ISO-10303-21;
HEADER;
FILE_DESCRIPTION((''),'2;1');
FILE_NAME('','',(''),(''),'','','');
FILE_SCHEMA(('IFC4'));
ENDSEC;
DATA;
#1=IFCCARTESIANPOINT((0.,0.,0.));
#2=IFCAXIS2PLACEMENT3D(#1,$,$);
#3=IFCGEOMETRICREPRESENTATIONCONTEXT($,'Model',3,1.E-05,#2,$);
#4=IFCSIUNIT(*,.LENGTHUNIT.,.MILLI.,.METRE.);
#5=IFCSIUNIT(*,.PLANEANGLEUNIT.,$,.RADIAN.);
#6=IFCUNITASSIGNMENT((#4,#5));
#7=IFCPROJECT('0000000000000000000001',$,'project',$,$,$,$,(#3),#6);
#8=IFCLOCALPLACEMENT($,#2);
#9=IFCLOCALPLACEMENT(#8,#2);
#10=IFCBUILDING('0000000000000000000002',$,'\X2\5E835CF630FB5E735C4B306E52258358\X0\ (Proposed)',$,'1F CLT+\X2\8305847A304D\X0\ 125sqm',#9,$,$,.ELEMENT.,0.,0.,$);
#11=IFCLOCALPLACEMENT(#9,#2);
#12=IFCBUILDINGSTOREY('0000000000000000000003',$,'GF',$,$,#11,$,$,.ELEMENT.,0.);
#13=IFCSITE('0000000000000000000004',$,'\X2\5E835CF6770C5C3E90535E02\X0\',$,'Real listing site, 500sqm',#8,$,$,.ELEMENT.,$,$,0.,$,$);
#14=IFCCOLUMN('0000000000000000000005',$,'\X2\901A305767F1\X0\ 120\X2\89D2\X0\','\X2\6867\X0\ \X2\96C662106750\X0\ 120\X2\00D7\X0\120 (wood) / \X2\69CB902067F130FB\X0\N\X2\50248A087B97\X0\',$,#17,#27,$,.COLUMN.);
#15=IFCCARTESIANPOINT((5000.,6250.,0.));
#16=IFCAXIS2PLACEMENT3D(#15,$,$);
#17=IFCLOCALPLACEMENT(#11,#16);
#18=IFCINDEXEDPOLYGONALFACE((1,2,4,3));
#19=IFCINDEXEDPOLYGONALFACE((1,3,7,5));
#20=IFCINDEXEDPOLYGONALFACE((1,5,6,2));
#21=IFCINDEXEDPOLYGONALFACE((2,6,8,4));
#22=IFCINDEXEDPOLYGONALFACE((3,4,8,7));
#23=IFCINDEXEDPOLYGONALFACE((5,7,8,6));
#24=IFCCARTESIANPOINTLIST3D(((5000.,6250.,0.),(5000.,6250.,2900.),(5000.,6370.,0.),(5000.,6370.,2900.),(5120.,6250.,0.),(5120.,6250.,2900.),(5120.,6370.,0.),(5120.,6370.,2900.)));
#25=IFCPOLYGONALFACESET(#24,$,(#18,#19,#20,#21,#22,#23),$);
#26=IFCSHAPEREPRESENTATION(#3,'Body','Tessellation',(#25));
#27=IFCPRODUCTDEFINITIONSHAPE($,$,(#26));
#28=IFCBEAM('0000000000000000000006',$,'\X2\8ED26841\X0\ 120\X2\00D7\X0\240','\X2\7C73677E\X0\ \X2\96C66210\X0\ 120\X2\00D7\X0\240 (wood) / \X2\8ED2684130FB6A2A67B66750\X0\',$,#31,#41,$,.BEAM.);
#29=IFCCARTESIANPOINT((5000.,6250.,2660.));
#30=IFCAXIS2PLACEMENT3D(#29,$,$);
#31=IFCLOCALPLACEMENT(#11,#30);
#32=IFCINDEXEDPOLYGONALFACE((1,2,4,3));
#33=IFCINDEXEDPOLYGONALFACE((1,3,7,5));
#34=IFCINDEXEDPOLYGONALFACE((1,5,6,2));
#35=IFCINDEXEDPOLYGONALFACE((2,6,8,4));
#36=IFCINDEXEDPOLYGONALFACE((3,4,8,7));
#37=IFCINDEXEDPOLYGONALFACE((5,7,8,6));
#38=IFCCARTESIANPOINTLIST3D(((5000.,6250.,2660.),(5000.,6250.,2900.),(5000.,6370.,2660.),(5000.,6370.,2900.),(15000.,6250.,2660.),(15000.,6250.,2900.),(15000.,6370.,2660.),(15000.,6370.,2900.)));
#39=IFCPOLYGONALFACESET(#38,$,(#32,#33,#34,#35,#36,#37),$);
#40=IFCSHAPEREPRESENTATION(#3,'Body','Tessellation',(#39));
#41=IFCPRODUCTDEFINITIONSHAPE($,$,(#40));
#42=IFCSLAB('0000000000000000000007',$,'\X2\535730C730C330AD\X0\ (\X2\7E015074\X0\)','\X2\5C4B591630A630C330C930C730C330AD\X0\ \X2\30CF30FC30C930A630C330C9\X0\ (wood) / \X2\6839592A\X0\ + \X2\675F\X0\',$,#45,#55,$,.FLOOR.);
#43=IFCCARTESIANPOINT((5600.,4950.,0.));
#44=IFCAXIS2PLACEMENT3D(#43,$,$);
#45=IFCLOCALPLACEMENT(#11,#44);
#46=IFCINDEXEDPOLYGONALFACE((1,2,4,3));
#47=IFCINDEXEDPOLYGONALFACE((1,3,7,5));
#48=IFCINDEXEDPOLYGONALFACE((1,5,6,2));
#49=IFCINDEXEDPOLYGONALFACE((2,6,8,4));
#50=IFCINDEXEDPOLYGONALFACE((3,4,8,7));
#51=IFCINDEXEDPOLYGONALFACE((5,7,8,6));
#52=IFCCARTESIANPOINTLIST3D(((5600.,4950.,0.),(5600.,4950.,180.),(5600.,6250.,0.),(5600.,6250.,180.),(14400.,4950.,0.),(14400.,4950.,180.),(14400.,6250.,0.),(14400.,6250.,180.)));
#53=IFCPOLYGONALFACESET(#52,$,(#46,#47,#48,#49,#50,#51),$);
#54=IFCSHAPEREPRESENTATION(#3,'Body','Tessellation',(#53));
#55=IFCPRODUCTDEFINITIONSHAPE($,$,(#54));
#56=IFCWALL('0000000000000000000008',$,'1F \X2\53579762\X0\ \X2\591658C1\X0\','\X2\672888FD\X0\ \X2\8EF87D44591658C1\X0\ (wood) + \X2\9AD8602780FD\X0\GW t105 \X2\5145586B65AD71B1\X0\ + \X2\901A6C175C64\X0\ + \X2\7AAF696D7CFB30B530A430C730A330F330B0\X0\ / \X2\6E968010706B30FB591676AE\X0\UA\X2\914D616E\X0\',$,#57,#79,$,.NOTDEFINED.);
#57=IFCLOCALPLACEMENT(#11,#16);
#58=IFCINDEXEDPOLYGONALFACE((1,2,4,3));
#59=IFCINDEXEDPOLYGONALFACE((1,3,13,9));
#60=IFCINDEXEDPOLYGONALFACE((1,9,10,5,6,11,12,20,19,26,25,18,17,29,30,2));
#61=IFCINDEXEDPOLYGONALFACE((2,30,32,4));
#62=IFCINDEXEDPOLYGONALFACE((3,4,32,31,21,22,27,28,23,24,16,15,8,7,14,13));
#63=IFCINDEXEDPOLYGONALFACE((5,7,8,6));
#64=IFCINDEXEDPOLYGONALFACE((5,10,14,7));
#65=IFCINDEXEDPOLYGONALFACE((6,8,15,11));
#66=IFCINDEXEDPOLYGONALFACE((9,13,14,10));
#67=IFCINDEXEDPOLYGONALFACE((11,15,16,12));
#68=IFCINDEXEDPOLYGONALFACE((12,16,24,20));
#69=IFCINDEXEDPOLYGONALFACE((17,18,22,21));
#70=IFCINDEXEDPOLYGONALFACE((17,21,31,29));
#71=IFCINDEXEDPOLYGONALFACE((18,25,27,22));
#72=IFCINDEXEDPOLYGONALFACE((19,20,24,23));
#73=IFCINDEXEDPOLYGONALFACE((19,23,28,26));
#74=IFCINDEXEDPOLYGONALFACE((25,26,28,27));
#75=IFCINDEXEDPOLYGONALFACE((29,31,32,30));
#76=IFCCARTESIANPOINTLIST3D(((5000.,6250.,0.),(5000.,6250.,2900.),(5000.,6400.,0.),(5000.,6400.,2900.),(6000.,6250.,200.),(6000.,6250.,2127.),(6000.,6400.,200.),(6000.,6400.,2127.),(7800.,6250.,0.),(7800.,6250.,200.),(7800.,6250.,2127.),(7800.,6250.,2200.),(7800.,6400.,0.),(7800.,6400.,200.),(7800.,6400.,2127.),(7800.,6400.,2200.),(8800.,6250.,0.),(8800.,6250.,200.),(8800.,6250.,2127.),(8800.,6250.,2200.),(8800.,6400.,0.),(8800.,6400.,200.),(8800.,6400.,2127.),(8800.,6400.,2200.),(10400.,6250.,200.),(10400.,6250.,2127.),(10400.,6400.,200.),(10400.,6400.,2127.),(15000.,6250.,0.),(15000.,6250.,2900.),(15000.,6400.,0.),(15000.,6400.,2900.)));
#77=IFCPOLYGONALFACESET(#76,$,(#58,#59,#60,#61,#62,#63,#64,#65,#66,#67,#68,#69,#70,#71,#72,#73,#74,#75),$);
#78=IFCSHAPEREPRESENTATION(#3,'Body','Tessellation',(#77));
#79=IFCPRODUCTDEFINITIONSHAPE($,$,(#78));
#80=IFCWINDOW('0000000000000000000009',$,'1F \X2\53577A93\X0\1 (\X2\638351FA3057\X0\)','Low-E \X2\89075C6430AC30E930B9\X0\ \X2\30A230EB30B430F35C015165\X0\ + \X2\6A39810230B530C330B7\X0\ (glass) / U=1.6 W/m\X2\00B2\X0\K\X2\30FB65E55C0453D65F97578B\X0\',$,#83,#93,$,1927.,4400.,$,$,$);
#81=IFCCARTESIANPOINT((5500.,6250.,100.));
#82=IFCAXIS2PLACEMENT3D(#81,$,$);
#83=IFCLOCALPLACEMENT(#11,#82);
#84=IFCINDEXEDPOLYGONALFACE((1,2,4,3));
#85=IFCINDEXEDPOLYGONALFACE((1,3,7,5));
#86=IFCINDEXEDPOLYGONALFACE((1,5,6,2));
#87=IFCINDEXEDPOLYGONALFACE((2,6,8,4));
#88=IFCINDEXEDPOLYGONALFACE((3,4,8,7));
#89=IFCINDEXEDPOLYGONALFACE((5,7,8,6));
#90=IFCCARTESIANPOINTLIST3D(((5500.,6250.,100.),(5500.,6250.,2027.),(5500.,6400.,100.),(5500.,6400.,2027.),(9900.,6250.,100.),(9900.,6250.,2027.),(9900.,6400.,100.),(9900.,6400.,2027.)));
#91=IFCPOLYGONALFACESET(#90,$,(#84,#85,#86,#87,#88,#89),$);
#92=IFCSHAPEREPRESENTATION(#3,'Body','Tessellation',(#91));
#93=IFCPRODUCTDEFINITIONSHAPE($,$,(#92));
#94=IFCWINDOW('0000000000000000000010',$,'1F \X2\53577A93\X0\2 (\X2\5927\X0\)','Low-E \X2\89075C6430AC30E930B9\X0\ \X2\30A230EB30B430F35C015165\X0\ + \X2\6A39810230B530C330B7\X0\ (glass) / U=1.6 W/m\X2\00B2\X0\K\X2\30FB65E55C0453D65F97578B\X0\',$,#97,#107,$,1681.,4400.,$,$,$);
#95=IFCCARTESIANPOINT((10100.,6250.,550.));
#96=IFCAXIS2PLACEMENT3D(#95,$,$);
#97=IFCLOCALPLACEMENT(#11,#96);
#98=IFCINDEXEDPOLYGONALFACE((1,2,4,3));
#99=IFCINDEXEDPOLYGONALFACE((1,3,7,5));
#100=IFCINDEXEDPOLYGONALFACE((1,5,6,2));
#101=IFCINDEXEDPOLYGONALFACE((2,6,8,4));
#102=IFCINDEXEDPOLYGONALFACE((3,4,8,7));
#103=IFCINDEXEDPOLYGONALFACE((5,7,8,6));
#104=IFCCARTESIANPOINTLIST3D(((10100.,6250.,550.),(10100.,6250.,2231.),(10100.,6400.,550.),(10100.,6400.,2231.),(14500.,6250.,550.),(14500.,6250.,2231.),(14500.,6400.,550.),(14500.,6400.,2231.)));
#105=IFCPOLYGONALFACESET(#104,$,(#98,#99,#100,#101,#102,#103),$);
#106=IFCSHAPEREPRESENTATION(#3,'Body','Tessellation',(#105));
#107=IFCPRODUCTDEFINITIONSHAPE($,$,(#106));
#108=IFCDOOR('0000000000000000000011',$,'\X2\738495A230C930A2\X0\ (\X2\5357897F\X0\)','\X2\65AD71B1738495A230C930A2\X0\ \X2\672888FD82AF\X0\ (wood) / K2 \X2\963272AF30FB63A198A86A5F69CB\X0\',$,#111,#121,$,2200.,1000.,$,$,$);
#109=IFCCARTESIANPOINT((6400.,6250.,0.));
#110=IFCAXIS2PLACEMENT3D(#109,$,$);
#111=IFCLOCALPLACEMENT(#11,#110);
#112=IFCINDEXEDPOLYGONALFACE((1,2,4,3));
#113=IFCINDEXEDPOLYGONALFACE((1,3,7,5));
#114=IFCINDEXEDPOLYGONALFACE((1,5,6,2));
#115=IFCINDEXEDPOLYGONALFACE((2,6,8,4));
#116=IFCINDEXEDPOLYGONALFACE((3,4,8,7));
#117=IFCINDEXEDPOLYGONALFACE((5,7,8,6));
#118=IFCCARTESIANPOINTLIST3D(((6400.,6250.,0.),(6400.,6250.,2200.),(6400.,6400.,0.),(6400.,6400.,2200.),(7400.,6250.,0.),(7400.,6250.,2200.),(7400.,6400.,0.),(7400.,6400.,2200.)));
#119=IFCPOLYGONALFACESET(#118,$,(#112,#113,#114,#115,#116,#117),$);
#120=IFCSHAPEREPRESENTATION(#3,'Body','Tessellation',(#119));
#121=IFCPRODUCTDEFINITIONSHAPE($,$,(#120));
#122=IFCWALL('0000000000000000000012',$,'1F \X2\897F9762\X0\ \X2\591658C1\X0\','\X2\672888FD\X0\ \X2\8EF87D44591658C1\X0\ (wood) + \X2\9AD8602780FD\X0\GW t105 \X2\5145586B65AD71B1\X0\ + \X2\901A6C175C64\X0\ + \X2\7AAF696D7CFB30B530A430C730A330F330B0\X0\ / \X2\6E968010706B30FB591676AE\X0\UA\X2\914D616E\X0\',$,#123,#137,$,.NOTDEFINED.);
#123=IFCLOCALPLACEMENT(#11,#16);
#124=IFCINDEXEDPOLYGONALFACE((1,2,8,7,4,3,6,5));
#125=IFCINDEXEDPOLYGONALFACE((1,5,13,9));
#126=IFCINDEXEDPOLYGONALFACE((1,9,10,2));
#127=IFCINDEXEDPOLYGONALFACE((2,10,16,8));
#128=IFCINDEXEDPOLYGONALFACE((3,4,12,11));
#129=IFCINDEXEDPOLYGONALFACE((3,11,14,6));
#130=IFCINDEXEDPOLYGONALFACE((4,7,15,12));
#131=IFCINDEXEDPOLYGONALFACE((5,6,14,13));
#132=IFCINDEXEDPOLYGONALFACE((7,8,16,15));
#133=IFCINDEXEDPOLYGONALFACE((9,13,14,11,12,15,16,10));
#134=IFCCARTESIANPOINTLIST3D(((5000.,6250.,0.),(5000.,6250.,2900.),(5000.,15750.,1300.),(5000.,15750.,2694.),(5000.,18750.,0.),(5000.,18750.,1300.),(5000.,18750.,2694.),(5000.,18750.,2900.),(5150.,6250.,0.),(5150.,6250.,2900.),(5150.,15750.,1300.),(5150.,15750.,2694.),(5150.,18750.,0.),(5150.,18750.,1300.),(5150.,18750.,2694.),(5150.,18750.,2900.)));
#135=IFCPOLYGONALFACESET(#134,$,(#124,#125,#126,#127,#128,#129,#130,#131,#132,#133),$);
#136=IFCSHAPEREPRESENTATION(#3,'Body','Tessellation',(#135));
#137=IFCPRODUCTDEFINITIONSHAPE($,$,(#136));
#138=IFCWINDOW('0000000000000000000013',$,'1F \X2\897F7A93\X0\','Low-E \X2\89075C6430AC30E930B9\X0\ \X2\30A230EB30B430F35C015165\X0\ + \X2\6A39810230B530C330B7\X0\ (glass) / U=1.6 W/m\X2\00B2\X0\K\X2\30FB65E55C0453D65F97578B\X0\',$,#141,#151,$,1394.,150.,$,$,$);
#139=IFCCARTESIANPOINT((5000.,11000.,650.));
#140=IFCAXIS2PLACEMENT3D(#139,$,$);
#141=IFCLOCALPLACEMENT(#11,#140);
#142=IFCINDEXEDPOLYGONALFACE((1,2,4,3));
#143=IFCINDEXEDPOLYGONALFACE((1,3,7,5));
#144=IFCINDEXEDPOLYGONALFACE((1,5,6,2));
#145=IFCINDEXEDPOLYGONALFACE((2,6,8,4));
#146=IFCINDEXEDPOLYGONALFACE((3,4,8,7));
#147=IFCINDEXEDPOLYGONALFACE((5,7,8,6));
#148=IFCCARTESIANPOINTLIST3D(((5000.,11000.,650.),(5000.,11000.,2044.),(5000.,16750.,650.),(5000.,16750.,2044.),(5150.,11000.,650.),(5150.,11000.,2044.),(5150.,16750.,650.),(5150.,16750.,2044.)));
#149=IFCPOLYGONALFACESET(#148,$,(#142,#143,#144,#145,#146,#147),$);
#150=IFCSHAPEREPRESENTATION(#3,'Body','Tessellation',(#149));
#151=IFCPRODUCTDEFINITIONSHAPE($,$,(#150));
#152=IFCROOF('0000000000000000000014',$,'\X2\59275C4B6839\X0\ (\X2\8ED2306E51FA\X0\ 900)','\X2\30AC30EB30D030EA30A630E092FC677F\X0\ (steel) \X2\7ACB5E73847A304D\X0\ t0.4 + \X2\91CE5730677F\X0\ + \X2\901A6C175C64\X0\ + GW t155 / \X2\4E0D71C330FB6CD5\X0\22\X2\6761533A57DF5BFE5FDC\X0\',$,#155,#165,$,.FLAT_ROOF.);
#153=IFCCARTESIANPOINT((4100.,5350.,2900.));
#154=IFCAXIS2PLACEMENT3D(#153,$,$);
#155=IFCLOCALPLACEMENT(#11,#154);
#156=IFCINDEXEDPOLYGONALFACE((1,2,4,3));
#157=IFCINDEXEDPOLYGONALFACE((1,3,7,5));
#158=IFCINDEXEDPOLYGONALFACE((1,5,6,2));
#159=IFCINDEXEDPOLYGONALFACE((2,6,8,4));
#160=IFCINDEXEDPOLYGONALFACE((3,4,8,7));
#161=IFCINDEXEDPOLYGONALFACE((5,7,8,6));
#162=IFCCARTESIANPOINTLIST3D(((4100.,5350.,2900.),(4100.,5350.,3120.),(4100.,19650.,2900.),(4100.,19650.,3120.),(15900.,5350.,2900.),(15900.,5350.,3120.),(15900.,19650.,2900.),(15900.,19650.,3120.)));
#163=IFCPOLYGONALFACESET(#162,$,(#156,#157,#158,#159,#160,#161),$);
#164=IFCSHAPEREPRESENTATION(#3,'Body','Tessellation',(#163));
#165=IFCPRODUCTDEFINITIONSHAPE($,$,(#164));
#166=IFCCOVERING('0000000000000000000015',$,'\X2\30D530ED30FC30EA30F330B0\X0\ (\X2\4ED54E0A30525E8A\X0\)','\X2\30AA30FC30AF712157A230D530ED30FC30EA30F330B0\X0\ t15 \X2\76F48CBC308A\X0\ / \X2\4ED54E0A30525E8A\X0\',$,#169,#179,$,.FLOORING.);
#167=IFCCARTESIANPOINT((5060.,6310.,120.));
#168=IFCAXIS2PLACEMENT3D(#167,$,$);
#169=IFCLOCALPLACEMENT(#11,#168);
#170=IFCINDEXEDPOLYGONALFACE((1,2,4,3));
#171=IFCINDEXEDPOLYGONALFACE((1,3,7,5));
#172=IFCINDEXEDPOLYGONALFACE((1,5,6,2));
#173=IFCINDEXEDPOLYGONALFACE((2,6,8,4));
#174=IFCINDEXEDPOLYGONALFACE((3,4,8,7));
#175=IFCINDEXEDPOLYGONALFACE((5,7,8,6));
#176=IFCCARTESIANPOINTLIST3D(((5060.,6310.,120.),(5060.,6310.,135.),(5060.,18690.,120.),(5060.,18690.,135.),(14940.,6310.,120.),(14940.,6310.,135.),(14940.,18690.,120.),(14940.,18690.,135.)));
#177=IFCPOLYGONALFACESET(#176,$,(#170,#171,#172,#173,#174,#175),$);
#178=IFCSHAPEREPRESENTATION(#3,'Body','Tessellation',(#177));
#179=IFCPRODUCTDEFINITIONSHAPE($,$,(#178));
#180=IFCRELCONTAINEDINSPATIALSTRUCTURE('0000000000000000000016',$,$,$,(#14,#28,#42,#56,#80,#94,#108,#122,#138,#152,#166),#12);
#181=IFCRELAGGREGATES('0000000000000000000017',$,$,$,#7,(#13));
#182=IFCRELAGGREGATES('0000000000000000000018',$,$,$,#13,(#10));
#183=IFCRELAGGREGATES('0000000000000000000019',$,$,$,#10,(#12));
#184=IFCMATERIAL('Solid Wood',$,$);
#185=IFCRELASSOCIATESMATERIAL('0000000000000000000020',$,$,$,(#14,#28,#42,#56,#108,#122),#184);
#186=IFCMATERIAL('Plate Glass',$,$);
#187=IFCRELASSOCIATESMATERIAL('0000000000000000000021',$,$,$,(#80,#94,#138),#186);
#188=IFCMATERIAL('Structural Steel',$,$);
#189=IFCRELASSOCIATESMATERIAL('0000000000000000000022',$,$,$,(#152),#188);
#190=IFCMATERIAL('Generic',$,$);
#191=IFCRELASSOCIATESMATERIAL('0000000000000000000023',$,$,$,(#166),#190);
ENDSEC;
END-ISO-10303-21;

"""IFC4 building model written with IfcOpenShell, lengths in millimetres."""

from ifc_helpers import new_model, si_unit, frame, frame_2d, origin, place, context, project, spatial, rectangle, extrude, material, element, fill, save


model = new_model("IFC4")

# Units and contexts
model_context = context("Model", 3, precision=1e-05, world=origin())
ifc_project = project(units=[si_unit("LENGTHUNIT", "METRE", prefix="MILLI"), si_unit("PLANEANGLEUNIT", "RADIAN")], contexts=[model_context])

# Site, building, storey
site_placement = place(None, origin())
site = spatial("IfcSite", under=ifc_project, at=site_placement, Name="広島県尾道市", ObjectType="Real listing site, 500sqm", CompositionType="ELEMENT", RefElevation=0.0)
building_placement = place(site_placement, origin())
building = spatial("IfcBuilding", under=site, at=building_placement, Name="広島・平屋の別荘 (Proposed)", ObjectType="1F CLT+茅葺き 125sqm", CompositionType="ELEMENT", ElevationOfRefHeight=0.0, ElevationOfTerrain=0.0)
storey_placement = place(building_placement, origin())
storey = spatial("IfcBuildingStorey", under=building, at=storey_placement, Name="GF", CompositionType="ELEMENT", Elevation=0.0)

# Column
ifc_material_1 = material(Name="Solid Wood")
column_1_placement = place(storey_placement, frame((5000.0, 6250.0, 0.0)))
element("IfcColumn", 1, at=column_1_placement, inside=storey, material=ifc_material_1, Name="通し柱 120角", Description="桧 集成材 120×120 (wood) / 構造柱・N値計算", PredefinedType="COLUMN", context=model_context, shape_type="SweptSolid", body=[
    extrude(rectangle(XDim=120.0, YDim=120.0, at=frame_2d((60.0, 60.0))), frame((5000.0, 6250.0, 0.0)), (0.0, 0.0, 1.0), 2900.0),
])

# Beam
beam_1_placement = place(storey_placement, frame((5000.0, 6250.0, 2660.0)))
element("IfcBeam", 2, at=beam_1_placement, inside=storey, material=ifc_material_1, Name="軒桁 120×240", Description="米松 集成 120×240 (wood) / 軒桁・横架材", PredefinedType="BEAM", context=model_context, shape_type="SweptSolid", body=[
    extrude(rectangle(XDim=10000.0, YDim=120.0, at=frame_2d((5000.0, 60.0))), frame((5000.0, 6250.0, 2660.0)), (0.0, 0.0, 1.0), 240.0),
])

# Slab
slab_1_placement = place(storey_placement, frame((5600.0, 4950.0, 0.0)))
element("IfcSlab", 3, at=slab_1_placement, inside=storey, material=ifc_material_1, Name="南デッキ (縁側)", Description="屋外ウッドデッキ ハードウッド (wood) / 根太 + 束", PredefinedType="FLOOR", context=model_context, shape_type="SweptSolid", body=[
    extrude(rectangle(XDim=8800.0, YDim=1300.0, at=frame_2d((4400.0, 650.0))), frame((5600.0, 4950.0, 0.0)), (0.0, 0.0, 1.0), 180.0),
])

# Wall, openings, windows, door
wall_1_placement = place(storey_placement, frame((5000.0, 6250.0, 0.0)))
wall_1 = element("IfcWall", 4, at=wall_1_placement, inside=storey, material=ifc_material_1, Name="1F 南面 外壁", Description="木製 軸組外壁 (wood) + 高性能GW t105 充填断熱 + 通気層 + 窯業系サイディング / 準耐火・外皮UA配慮", PredefinedType="NOTDEFINED", context=model_context, shape_type="SweptSolid", body=[
    extrude(rectangle(XDim=10000.0, YDim=150.0, at=frame_2d((5000.0, 75.0))), frame((5000.0, 6250.0, 0.0)), (0.0, 0.0, 1.0), 2900.0),
])
opening_1_placement = place(storey_placement, frame((5500.0, 6250.0, 100.0)))
opening_1 = element("IfcOpeningElement", 5, at=opening_1_placement, cuts=wall_1, PredefinedType="NOTDEFINED", context=model_context, shape_type="SweptSolid", body=[
    extrude(rectangle(XDim=4400.0, YDim=150.0, at=frame_2d((2200.0, 75.0))), frame((5500.0, 6250.0, 100.0)), (0.0, 0.0, 1.0), 1927.0),
])
opening_2_placement = place(storey_placement, frame((10100.0, 6250.0, 550.0)))
opening_2 = element("IfcOpeningElement", 6, at=opening_2_placement, cuts=wall_1, PredefinedType="NOTDEFINED", context=model_context, shape_type="SweptSolid", body=[
    extrude(rectangle(XDim=4400.0, YDim=150.0, at=frame_2d((2200.0, 75.0))), frame((10100.0, 6250.0, 550.0)), (0.0, 0.0, 1.0), 1681.0),
])
opening_3_placement = place(storey_placement, frame((6400.0, 6250.0, 0.0)))
opening_3 = element("IfcOpeningElement", 7, at=opening_3_placement, cuts=wall_1, PredefinedType="NOTDEFINED", context=model_context, shape_type="SweptSolid", body=[
    extrude(rectangle(XDim=1000.0, YDim=150.0, at=frame_2d((500.0, 75.0))), frame((6400.0, 6250.0, 0.0)), (0.0, 0.0, 1.0), 2200.0),
])
ifc_material_2 = material(Name="Plate Glass")
window_1_placement = place(storey_placement, frame((5500.0, 6250.0, 100.0)))
window_1 = element("IfcWindow", 8, at=window_1_placement, inside=storey, material=ifc_material_2, Name="1F 南窓1 (掃出し)", Description="Low-E 複層ガラス アルゴン封入 + 樹脂サッシ (glass) / U=1.6 W/m²K・日射取得型", OverallHeight=1927.0, OverallWidth=4400.0, context=model_context, shape_type="SweptSolid", body=[
    extrude(rectangle(XDim=4400.0, YDim=150.0, at=frame_2d((2200.0, 75.0))), frame((5500.0, 6250.0, 100.0)), (0.0, 0.0, 1.0), 1927.0),
])
fill(opening_1, window_1)
window_2_placement = place(storey_placement, frame((10100.0, 6250.0, 550.0)))
window_2 = element("IfcWindow", 9, at=window_2_placement, inside=storey, material=ifc_material_2, Name="1F 南窓2 (大)", Description="Low-E 複層ガラス アルゴン封入 + 樹脂サッシ (glass) / U=1.6 W/m²K・日射取得型", OverallHeight=1681.0, OverallWidth=4400.0, context=model_context, shape_type="SweptSolid", body=[
    extrude(rectangle(XDim=4400.0, YDim=150.0, at=frame_2d((2200.0, 75.0))), frame((10100.0, 6250.0, 550.0)), (0.0, 0.0, 1.0), 1681.0),
])
fill(opening_2, window_2)
door_placement = place(storey_placement, frame((6400.0, 6250.0, 0.0)))
door = element("IfcDoor", 10, at=door_placement, inside=storey, material=ifc_material_1, Name="玄関ドア (南西)", Description="断熱玄関ドア 木製芯 (wood) / K2 防犯・採風機構", OverallHeight=2200.0, OverallWidth=1000.0, context=model_context, shape_type="SweptSolid", body=[
    extrude(rectangle(XDim=1000.0, YDim=150.0, at=frame_2d((500.0, 75.0))), frame((6400.0, 6250.0, 0.0)), (0.0, 0.0, 1.0), 2200.0),
])
fill(opening_3, door)

# Wall, opening, window
wall_2_placement = place(storey_placement, frame((5000.0, 6250.0, 0.0)))
wall_2 = element("IfcWall", 11, at=wall_2_placement, inside=storey, material=ifc_material_1, Name="1F 西面 外壁", Description="木製 軸組外壁 (wood) + 高性能GW t105 充填断熱 + 通気層 + 窯業系サイディング / 準耐火・外皮UA配慮", PredefinedType="NOTDEFINED", context=model_context, shape_type="SweptSolid", body=[
    extrude(rectangle(XDim=150.0, YDim=12500.0, at=frame_2d((75.0, 6250.0))), frame((5000.0, 6250.0, 0.0)), (0.0, 0.0, 1.0), 2900.0),
])
opening_4_placement = place(storey_placement, frame((5000.0, 11000.0, 650.0)))
opening_4 = element("IfcOpeningElement", 12, at=opening_4_placement, cuts=wall_2, PredefinedType="NOTDEFINED", context=model_context, shape_type="SweptSolid", body=[
    extrude(rectangle(XDim=150.0, YDim=5750.0, at=frame_2d((75.0, 2875.0))), frame((5000.0, 11000.0, 650.0)), (0.0, 0.0, 1.0), 1394.0),
])
window_3_placement = place(storey_placement, frame((5000.0, 11000.0, 650.0)))
window_3 = element("IfcWindow", 13, at=window_3_placement, inside=storey, material=ifc_material_2, Name="1F 西窓", Description="Low-E 複層ガラス アルゴン封入 + 樹脂サッシ (glass) / U=1.6 W/m²K・日射取得型", OverallHeight=1394.0, OverallWidth=150.0, context=model_context, shape_type="SweptSolid", body=[
    extrude(rectangle(XDim=150.0, YDim=5750.0, at=frame_2d((75.0, 2875.0))), frame((5000.0, 11000.0, 650.0)), (0.0, 0.0, 1.0), 1394.0),
])
fill(opening_4, window_3)

# Roof
ifc_material_3 = material(Name="Structural Steel")
roof_placement = place(storey_placement, frame((4100.0, 5350.0, 2900.0)))
element("IfcRoof", 14, at=roof_placement, inside=storey, material=ifc_material_3, Name="大屋根 (軒の出 900)", Description="ガルバリウム鋼板 (steel) 立平葺き t0.4 + 野地板 + 通気層 + GW t155 / 不燃・法22条区域対応", PredefinedType="FLAT_ROOF", context=model_context, shape_type="SweptSolid", body=[
    extrude(rectangle(XDim=11800.0, YDim=14300.0, at=frame_2d((5900.0, 7150.0))), frame((4100.0, 5350.0, 2900.0)), (0.0, 0.0, 1.0), 220.0),
])

# Covering
ifc_material_4 = material(Name="Generic")
covering_1_placement = place(storey_placement, frame((5060.0, 6310.0, 120.0)))
element("IfcCovering", 15, at=covering_1_placement, inside=storey, material=ifc_material_4, Name="フローリング (仕上げ床)", Description="オーク無垢フローリング t15 直貼り / 仕上げ床", PredefinedType="FLOORING", context=model_context, shape_type="SweptSolid", body=[
    extrude(rectangle(XDim=9880.0, YDim=12380.0, at=frame_2d((4940.0, 6190.0))), frame((5060.0, 6310.0, 120.0)), (0.0, 0.0, 1.0), 15.0),
])

save(model, "model.ifc")
